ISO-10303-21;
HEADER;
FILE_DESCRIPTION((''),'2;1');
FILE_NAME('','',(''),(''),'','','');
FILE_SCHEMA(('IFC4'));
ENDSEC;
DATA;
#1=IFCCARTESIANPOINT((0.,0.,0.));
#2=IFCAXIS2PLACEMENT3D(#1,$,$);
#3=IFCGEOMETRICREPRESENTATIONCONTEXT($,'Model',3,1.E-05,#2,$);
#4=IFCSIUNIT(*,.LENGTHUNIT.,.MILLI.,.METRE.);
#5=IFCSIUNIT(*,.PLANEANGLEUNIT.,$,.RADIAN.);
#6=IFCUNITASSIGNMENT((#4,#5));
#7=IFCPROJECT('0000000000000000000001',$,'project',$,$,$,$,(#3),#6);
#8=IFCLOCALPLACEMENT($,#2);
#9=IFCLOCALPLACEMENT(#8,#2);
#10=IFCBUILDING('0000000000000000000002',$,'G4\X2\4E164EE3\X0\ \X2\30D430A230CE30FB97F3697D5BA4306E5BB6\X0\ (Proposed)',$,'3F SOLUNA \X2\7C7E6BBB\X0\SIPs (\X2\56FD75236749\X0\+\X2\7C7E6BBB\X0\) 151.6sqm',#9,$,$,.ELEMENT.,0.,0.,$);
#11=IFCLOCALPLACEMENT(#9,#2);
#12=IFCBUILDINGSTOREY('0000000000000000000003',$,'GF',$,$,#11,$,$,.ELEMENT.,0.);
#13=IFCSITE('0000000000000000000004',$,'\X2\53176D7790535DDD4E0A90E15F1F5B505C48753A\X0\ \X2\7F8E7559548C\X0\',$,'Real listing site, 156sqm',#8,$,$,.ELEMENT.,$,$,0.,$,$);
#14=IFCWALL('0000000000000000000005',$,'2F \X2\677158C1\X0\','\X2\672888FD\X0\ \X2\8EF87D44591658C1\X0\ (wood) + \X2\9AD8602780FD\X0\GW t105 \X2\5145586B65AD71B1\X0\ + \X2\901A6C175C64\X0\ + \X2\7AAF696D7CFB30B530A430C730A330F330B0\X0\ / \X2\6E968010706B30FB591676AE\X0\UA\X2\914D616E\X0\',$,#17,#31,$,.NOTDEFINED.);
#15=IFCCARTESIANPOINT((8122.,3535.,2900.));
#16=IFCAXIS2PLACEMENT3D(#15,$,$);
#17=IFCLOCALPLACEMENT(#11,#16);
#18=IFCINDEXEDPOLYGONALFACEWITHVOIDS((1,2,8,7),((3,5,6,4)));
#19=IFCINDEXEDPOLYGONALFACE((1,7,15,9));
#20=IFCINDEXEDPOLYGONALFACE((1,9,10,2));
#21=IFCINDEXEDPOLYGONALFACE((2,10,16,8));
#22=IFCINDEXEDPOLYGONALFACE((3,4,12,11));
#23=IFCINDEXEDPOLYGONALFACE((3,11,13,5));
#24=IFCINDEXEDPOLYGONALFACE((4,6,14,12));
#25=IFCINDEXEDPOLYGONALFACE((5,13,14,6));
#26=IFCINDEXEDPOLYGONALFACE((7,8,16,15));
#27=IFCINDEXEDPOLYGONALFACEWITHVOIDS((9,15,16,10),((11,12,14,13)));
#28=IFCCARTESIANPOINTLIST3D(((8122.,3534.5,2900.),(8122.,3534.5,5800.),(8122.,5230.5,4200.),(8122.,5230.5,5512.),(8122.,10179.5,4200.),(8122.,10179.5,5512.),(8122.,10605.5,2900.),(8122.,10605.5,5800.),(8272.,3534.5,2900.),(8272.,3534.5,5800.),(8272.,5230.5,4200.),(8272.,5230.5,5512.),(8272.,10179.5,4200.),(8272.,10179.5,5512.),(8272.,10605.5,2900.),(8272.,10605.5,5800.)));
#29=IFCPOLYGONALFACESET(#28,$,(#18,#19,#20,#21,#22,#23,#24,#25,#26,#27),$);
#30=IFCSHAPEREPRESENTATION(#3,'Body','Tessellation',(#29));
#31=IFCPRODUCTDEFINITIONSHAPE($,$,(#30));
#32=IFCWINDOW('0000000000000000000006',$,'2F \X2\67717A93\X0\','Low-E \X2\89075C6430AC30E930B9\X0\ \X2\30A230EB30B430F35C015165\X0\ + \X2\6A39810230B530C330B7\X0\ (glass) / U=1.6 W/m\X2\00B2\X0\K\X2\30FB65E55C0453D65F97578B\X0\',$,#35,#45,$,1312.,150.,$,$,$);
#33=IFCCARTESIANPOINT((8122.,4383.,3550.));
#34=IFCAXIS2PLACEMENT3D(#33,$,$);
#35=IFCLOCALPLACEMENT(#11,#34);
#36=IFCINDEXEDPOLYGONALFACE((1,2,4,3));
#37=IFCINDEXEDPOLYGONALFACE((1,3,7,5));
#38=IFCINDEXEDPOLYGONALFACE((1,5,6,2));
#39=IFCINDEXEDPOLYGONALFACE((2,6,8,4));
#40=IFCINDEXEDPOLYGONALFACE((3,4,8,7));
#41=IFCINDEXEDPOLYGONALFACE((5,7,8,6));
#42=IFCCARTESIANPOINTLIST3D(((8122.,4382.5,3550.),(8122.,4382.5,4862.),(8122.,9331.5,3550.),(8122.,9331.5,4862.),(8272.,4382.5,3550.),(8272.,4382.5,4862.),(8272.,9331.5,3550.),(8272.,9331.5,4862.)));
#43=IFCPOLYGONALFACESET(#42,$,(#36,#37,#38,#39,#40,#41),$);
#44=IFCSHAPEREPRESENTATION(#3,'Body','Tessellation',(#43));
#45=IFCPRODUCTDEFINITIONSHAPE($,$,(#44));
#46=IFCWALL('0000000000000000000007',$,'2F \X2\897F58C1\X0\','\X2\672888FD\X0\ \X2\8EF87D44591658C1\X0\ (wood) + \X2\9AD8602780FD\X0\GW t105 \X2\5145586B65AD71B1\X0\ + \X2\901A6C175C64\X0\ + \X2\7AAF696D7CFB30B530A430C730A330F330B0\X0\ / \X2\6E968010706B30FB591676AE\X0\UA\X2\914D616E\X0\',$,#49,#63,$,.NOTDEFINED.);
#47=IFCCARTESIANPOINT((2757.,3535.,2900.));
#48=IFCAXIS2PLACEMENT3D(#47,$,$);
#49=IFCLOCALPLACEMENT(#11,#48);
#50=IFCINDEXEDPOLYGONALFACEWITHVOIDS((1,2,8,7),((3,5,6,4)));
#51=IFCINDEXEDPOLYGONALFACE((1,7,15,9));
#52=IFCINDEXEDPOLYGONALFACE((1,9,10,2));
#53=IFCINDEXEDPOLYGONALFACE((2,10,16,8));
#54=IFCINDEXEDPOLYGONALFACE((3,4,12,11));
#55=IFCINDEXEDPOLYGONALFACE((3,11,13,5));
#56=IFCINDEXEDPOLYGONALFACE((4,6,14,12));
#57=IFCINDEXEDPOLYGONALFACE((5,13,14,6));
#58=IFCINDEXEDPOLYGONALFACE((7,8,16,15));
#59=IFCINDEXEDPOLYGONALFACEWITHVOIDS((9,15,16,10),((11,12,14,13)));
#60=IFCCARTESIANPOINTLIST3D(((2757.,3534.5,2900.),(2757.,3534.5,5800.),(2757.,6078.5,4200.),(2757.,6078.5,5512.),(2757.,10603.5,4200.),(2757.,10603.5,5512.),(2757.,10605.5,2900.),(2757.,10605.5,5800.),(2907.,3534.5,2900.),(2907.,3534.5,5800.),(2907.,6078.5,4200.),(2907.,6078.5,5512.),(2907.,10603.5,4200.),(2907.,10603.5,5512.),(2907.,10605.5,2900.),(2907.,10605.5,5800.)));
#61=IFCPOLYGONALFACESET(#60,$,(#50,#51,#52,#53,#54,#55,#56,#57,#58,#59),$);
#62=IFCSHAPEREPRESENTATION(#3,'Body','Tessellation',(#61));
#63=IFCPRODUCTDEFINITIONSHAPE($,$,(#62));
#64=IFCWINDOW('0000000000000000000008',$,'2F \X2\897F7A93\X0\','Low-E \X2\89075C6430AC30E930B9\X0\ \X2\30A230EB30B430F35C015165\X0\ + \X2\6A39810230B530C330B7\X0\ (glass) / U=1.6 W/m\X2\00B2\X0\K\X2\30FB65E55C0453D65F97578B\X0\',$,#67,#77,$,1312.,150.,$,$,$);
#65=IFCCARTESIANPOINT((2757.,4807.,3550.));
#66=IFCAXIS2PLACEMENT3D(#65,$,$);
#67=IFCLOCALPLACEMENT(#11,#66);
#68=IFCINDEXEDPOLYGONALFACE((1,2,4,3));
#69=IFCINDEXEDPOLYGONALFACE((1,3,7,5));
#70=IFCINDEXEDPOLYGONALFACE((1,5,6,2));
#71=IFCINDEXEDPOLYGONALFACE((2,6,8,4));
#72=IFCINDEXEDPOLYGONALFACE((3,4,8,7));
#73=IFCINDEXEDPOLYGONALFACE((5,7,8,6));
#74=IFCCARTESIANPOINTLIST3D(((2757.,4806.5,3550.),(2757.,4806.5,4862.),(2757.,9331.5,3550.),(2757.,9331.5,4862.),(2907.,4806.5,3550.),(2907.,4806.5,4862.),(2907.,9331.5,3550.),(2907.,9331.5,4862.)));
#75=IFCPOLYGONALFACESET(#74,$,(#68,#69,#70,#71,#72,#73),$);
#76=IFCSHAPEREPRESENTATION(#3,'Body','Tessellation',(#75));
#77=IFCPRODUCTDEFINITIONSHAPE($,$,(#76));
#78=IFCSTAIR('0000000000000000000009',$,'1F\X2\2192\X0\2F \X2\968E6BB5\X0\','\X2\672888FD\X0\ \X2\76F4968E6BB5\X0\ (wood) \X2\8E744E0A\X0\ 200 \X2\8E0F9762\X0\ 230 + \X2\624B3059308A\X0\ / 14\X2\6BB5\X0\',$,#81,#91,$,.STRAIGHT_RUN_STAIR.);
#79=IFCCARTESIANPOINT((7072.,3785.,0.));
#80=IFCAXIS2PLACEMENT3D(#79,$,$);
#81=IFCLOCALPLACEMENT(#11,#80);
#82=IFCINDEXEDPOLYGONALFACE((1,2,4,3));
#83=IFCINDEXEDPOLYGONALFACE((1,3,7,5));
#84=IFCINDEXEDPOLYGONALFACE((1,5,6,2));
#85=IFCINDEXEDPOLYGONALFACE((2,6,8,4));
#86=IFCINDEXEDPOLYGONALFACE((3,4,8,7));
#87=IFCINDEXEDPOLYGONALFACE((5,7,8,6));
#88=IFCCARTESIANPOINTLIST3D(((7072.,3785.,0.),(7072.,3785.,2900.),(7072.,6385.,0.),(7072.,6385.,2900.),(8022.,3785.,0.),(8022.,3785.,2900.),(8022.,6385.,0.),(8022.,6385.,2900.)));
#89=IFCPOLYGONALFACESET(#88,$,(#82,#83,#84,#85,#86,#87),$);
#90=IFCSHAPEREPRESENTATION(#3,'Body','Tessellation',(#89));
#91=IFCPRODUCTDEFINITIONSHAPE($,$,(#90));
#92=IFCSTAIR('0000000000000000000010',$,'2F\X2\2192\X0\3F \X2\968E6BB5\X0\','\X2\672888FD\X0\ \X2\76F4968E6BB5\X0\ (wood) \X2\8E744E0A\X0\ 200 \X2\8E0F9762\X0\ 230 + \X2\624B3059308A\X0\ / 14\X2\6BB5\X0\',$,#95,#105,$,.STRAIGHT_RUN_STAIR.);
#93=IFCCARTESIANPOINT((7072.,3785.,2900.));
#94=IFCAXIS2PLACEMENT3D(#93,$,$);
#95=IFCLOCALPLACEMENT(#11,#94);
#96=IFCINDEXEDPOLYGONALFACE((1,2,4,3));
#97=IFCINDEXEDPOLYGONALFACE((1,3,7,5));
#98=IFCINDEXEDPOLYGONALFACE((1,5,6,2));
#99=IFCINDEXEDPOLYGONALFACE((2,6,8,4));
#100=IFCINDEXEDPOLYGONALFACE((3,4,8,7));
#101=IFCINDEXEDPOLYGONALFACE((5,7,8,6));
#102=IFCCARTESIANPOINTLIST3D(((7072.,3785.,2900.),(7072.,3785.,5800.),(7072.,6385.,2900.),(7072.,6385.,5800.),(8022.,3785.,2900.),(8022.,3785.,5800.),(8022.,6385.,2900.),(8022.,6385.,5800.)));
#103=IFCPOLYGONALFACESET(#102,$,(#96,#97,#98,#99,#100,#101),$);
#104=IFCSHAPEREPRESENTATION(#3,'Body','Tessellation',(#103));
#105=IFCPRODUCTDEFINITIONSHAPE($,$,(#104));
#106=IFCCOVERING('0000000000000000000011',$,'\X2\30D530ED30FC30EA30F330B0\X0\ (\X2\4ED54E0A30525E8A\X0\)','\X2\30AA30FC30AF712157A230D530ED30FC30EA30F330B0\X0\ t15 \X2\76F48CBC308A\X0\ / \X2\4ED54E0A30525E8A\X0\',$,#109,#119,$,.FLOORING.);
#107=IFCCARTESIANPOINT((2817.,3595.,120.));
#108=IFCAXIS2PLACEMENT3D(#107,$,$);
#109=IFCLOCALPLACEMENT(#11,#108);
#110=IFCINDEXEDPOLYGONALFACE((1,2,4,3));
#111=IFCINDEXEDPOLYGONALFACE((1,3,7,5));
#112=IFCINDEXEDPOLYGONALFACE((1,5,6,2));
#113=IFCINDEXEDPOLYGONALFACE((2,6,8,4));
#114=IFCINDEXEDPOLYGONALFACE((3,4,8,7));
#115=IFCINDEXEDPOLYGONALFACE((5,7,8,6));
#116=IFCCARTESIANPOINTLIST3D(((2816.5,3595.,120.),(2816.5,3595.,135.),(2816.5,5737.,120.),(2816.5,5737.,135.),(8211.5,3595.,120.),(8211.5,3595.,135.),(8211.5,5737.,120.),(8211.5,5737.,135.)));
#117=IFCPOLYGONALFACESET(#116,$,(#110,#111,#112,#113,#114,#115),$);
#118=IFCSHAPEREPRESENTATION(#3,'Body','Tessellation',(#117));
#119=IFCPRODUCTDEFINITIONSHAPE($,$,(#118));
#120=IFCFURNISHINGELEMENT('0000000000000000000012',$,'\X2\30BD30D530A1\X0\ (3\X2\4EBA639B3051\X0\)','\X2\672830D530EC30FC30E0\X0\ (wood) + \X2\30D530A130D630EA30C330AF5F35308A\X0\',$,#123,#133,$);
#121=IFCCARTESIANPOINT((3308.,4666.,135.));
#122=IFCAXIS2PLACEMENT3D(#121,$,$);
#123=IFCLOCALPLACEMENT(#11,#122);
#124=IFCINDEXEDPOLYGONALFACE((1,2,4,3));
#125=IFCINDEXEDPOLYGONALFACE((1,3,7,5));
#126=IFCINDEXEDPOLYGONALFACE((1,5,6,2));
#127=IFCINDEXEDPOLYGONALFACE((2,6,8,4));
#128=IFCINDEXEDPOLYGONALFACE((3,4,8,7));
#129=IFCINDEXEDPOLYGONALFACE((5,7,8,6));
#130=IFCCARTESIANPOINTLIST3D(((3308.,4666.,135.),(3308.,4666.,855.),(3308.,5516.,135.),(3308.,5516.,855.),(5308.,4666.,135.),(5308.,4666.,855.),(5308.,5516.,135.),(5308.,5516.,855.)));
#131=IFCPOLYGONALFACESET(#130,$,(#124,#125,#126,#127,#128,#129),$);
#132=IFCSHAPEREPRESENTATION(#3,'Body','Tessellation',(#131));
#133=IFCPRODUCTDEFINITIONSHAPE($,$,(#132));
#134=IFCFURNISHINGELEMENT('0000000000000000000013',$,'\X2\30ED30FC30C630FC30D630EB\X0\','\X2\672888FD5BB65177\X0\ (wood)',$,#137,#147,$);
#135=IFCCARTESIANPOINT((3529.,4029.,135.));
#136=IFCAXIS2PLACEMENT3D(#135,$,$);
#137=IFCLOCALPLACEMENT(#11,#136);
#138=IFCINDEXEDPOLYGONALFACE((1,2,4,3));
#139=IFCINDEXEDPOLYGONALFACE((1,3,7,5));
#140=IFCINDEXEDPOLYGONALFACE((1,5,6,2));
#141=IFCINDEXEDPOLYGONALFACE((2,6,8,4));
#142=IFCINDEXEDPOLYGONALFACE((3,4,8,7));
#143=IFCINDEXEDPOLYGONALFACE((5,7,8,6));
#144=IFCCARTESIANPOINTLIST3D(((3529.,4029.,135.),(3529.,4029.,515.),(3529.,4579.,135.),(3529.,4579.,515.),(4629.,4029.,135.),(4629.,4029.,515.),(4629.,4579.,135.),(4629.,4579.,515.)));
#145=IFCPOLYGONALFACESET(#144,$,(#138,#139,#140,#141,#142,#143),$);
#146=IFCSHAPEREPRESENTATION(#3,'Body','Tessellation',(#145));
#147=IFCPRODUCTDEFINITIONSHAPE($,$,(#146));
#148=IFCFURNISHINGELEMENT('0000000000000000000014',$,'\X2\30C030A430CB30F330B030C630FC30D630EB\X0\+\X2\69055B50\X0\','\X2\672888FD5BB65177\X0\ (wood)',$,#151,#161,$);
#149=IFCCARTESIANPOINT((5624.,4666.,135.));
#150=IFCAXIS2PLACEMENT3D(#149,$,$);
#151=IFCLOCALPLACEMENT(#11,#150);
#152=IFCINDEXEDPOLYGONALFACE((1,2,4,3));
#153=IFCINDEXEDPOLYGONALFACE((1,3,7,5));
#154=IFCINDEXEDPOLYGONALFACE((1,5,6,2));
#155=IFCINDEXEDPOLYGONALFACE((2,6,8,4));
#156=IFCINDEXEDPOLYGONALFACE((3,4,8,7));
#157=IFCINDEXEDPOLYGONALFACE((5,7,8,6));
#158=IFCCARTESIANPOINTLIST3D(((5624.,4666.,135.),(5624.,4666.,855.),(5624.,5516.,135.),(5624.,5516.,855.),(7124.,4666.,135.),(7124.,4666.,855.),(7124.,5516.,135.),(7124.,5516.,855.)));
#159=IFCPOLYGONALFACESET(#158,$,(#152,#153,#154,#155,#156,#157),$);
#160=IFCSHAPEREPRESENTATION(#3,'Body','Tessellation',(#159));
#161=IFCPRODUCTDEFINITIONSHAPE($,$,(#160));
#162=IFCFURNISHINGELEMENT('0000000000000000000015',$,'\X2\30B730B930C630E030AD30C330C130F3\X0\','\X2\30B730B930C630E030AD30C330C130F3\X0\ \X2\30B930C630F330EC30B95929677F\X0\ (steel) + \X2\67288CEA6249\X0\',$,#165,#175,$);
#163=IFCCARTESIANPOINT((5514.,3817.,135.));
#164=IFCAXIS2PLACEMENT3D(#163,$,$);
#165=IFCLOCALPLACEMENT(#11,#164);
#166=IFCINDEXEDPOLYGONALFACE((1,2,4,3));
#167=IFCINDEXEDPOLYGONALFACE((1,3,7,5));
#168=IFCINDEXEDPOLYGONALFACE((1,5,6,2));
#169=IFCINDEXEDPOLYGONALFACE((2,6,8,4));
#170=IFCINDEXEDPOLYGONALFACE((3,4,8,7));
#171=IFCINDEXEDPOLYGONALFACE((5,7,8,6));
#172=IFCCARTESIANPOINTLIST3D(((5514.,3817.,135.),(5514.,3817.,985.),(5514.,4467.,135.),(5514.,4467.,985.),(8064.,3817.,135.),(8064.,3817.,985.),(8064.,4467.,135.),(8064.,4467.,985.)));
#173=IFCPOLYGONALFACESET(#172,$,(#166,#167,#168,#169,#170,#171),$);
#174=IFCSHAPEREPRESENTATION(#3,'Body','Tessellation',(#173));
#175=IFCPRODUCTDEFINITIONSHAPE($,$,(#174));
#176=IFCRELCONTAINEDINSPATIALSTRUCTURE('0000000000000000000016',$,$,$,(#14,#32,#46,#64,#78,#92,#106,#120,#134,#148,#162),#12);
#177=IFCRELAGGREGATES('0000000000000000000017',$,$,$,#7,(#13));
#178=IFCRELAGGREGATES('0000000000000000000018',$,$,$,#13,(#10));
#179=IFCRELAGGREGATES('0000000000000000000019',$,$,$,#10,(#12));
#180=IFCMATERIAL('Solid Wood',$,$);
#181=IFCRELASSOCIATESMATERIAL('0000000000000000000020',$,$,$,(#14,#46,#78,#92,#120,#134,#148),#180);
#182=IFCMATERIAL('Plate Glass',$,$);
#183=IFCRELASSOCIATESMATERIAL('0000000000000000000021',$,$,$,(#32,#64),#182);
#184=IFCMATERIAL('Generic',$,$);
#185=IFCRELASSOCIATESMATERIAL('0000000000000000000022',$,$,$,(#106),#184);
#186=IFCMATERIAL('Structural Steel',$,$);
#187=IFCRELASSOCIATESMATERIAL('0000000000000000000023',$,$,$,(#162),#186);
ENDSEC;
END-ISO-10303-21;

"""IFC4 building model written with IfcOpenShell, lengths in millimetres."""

from ifc_helpers import new_model, si_unit, frame, frame_2d, origin, place, context, project, spatial, rectangle, extrude, material, element, fill, save


model = new_model("IFC4")

# Units and contexts
model_context = context("Model", 3, precision=1e-05, world=origin())
ifc_project = project(units=[si_unit("LENGTHUNIT", "METRE", prefix="MILLI"), si_unit("PLANEANGLEUNIT", "RADIAN")], contexts=[model_context])

# Site, building, storey
site_placement = place(None, origin())
site = spatial("IfcSite", under=ifc_project, at=site_placement, Name="北海道川上郡弟子屈町 美留和", ObjectType="Real listing site, 156sqm", CompositionType="ELEMENT", RefElevation=0.0)
building_placement = place(site_placement, origin())
building = spatial("IfcBuilding", under=site, at=building_placement, Name="G4世代 ピアノ・音楽室の家 (Proposed)", ObjectType="3F SOLUNA 籾殻SIPs (国産杉+籾殻) 151.6sqm", CompositionType="ELEMENT", ElevationOfRefHeight=0.0, ElevationOfTerrain=0.0)
storey_placement = place(building_placement, origin())
storey = spatial("IfcBuildingStorey", under=building, at=storey_placement, Name="GF", CompositionType="ELEMENT", Elevation=0.0)

# Shared definitions
ifc_material_1 = material(Name="Solid Wood")
ifc_material_2 = material(Name="Generic")

# Shared definitions
ifc_material_3 = material(Name="Plate Glass")

# Walls, openings, windows
wall_1_placement = place(storey_placement, frame((8122.0, 3535.0, 2900.0)))
wall_1 = element("IfcWall", 1, at=wall_1_placement, inside=storey, material=ifc_material_1, Name="2F 東壁", Description="木製 軸組外壁 (wood) + 高性能GW t105 充填断熱 + 通気層 + 窯業系サイディング / 準耐火・外皮UA配慮", PredefinedType="NOTDEFINED", context=model_context, shape_type="SweptSolid", body=[
    extrude(rectangle(XDim=150.0, YDim=7071.0, at=frame_2d((75.0, 3535.0))), frame((8122.0, 3535.0, 2900.0)), (0.0, 0.0, 1.0), 2900.0),
])
opening_1_placement = place(storey_placement, frame((8122.0, 4383.0, 3550.0)))
opening_1 = element("IfcOpeningElement", 2, at=opening_1_placement, cuts=wall_1, PredefinedType="NOTDEFINED", context=model_context, shape_type="SweptSolid", body=[
    extrude(rectangle(XDim=150.0, YDim=4949.0, at=frame_2d((75.0, 2474.0))), frame((8122.0, 4383.0, 3550.0)), (0.0, 0.0, 1.0), 1312.0),
])
window_1_placement = place(storey_placement, frame((8122.0, 4383.0, 3550.0)))
window_1 = element("IfcWindow", 3, at=window_1_placement, inside=storey, material=ifc_material_3, Name="2F 東窓", Description="Low-E 複層ガラス アルゴン封入 + 樹脂サッシ (glass) / U=1.6 W/m²K・日射取得型", OverallHeight=1312.0, OverallWidth=150.0, context=model_context, shape_type="SweptSolid", body=[
    extrude(rectangle(XDim=150.0, YDim=4949.0, at=frame_2d((75.0, 2474.0))), frame((8122.0, 4383.0, 3550.0)), (0.0, 0.0, 1.0), 1312.0),
])
fill(opening_1, window_1)
wall_2_placement = place(storey_placement, frame((2757.0, 3535.0, 2900.0)))
wall_2 = element("IfcWall", 4, at=wall_2_placement, inside=storey, material=ifc_material_1, Name="2F 西壁", Description="木製 軸組外壁 (wood) + 高性能GW t105 充填断熱 + 通気層 + 窯業系サイディング / 準耐火・外皮UA配慮", PredefinedType="NOTDEFINED", context=model_context, shape_type="SweptSolid", body=[
    extrude(rectangle(XDim=150.0, YDim=7071.0, at=frame_2d((75.0, 3535.0))), frame((2757.0, 3535.0, 2900.0)), (0.0, 0.0, 1.0), 2900.0),
])
opening_2_placement = place(storey_placement, frame((2757.0, 4807.0, 3550.0)))
opening_2 = element("IfcOpeningElement", 5, at=opening_2_placement, cuts=wall_2, PredefinedType="NOTDEFINED", context=model_context, shape_type="SweptSolid", body=[
    extrude(rectangle(XDim=150.0, YDim=4525.0, at=frame_2d((75.0, 2262.0))), frame((2757.0, 4807.0, 3550.0)), (0.0, 0.0, 1.0), 1312.0),
])
window_2_placement = place(storey_placement, frame((2757.0, 4807.0, 3550.0)))
window_2 = element("IfcWindow", 6, at=window_2_placement, inside=storey, material=ifc_material_3, Name="2F 西窓", Description="Low-E 複層ガラス アルゴン封入 + 樹脂サッシ (glass) / U=1.6 W/m²K・日射取得型", OverallHeight=1312.0, OverallWidth=150.0, context=model_context, shape_type="SweptSolid", body=[
    extrude(rectangle(XDim=150.0, YDim=4525.0, at=frame_2d((75.0, 2262.0))), frame((2757.0, 4807.0, 3550.0)), (0.0, 0.0, 1.0), 1312.0),
])
fill(opening_2, window_2)

# Stairs
stair_1_placement = place(storey_placement, frame((7072.0, 3785.0, 0.0)))
element("IfcStair", 7, at=stair_1_placement, inside=storey, material=ifc_material_1, Name="1F→2F 階段", Description="木製 直階段 (wood) 蹴上 200 踏面 230 + 手すり / 14段", PredefinedType="STRAIGHT_RUN_STAIR", context=model_context, shape_type="SweptSolid", body=[
    extrude(rectangle(XDim=950.0, YDim=2600.0, at=frame_2d((475.0, 1300.0))), frame((7072.0, 3785.0, 0.0)), (0.0, 0.0, 1.0), 2900.0),
])
stair_2_placement = place(storey_placement, frame((7072.0, 3785.0, 2900.0)))
element("IfcStair", 8, at=stair_2_placement, inside=storey, material=ifc_material_1, Name="2F→3F 階段", Description="木製 直階段 (wood) 蹴上 200 踏面 230 + 手すり / 14段", PredefinedType="STRAIGHT_RUN_STAIR", context=model_context, shape_type="SweptSolid", body=[
    extrude(rectangle(XDim=950.0, YDim=2600.0, at=frame_2d((475.0, 1300.0))), frame((7072.0, 3785.0, 2900.0)), (0.0, 0.0, 1.0), 2900.0),
])

# Covering
covering_placement = place(storey_placement, frame((2817.0, 3595.0, 120.0)))
element("IfcCovering", 9, at=covering_placement, inside=storey, material=ifc_material_2, Name="フローリング (仕上げ床)", Description="オーク無垢フローリング t15 直貼り / 仕上げ床", PredefinedType="FLOORING", context=model_context, shape_type="SweptSolid", body=[
    extrude(rectangle(XDim=5395.0, YDim=2142.0, at=frame_2d((2697.0, 1071.0))), frame((2817.0, 3595.0, 120.0)), (0.0, 0.0, 1.0), 15.0),
])

# Furnishing elements
furnishing_1_placement = place(storey_placement, frame((3308.0, 4666.0, 135.0)))
element("IfcFurnishingElement", 10, at=furnishing_1_placement, inside=storey, material=ifc_material_1, Name="ソファ (3人掛け)", Description="木フレーム (wood) + ファブリック張り", context=model_context, shape_type="SweptSolid", body=[
    extrude(rectangle(XDim=2000.0, YDim=850.0, at=frame_2d((1000.0, 425.0))), frame((3308.0, 4666.0, 135.0)), (0.0, 0.0, 1.0), 720.0),
])
furnishing_2_placement = place(storey_placement, frame((3529.0, 4029.0, 135.0)))
element("IfcFurnishingElement", 11, at=furnishing_2_placement, inside=storey, material=ifc_material_1, Name="ローテーブル", Description="木製家具 (wood)", context=model_context, shape_type="SweptSolid", body=[
    extrude(rectangle(XDim=1100.0, YDim=550.0, at=frame_2d((550.0, 275.0))), frame((3529.0, 4029.0, 135.0)), (0.0, 0.0, 1.0), 380.0),
])
furnishing_3_placement = place(storey_placement, frame((5624.0, 4666.0, 135.0)))
element("IfcFurnishingElement", 12, at=furnishing_3_placement, inside=storey, material=ifc_material_1, Name="ダイニングテーブル+椅子", Description="木製家具 (wood)", context=model_context, shape_type="SweptSolid", body=[
    extrude(rectangle(XDim=1500.0, YDim=850.0, at=frame_2d((750.0, 425.0))), frame((5624.0, 4666.0, 135.0)), (0.0, 0.0, 1.0), 720.0),
])
ifc_material_4 = material(Name="Structural Steel")
furnishing_4_placement = place(storey_placement, frame((5514.0, 3817.0, 135.0)))
element("IfcFurnishingElement", 13, at=furnishing_4_placement, inside=storey, material=ifc_material_4, Name="システムキッチン", Description="システムキッチン ステンレス天板 (steel) + 木質扉", context=model_context, shape_type="SweptSolid", body=[
    extrude(rectangle(XDim=2550.0, YDim=650.0, at=frame_2d((1275.0, 325.0))), frame((5514.0, 3817.0, 135.0)), (0.0, 0.0, 1.0), 850.0),
])

save(model, "model.ifc")
